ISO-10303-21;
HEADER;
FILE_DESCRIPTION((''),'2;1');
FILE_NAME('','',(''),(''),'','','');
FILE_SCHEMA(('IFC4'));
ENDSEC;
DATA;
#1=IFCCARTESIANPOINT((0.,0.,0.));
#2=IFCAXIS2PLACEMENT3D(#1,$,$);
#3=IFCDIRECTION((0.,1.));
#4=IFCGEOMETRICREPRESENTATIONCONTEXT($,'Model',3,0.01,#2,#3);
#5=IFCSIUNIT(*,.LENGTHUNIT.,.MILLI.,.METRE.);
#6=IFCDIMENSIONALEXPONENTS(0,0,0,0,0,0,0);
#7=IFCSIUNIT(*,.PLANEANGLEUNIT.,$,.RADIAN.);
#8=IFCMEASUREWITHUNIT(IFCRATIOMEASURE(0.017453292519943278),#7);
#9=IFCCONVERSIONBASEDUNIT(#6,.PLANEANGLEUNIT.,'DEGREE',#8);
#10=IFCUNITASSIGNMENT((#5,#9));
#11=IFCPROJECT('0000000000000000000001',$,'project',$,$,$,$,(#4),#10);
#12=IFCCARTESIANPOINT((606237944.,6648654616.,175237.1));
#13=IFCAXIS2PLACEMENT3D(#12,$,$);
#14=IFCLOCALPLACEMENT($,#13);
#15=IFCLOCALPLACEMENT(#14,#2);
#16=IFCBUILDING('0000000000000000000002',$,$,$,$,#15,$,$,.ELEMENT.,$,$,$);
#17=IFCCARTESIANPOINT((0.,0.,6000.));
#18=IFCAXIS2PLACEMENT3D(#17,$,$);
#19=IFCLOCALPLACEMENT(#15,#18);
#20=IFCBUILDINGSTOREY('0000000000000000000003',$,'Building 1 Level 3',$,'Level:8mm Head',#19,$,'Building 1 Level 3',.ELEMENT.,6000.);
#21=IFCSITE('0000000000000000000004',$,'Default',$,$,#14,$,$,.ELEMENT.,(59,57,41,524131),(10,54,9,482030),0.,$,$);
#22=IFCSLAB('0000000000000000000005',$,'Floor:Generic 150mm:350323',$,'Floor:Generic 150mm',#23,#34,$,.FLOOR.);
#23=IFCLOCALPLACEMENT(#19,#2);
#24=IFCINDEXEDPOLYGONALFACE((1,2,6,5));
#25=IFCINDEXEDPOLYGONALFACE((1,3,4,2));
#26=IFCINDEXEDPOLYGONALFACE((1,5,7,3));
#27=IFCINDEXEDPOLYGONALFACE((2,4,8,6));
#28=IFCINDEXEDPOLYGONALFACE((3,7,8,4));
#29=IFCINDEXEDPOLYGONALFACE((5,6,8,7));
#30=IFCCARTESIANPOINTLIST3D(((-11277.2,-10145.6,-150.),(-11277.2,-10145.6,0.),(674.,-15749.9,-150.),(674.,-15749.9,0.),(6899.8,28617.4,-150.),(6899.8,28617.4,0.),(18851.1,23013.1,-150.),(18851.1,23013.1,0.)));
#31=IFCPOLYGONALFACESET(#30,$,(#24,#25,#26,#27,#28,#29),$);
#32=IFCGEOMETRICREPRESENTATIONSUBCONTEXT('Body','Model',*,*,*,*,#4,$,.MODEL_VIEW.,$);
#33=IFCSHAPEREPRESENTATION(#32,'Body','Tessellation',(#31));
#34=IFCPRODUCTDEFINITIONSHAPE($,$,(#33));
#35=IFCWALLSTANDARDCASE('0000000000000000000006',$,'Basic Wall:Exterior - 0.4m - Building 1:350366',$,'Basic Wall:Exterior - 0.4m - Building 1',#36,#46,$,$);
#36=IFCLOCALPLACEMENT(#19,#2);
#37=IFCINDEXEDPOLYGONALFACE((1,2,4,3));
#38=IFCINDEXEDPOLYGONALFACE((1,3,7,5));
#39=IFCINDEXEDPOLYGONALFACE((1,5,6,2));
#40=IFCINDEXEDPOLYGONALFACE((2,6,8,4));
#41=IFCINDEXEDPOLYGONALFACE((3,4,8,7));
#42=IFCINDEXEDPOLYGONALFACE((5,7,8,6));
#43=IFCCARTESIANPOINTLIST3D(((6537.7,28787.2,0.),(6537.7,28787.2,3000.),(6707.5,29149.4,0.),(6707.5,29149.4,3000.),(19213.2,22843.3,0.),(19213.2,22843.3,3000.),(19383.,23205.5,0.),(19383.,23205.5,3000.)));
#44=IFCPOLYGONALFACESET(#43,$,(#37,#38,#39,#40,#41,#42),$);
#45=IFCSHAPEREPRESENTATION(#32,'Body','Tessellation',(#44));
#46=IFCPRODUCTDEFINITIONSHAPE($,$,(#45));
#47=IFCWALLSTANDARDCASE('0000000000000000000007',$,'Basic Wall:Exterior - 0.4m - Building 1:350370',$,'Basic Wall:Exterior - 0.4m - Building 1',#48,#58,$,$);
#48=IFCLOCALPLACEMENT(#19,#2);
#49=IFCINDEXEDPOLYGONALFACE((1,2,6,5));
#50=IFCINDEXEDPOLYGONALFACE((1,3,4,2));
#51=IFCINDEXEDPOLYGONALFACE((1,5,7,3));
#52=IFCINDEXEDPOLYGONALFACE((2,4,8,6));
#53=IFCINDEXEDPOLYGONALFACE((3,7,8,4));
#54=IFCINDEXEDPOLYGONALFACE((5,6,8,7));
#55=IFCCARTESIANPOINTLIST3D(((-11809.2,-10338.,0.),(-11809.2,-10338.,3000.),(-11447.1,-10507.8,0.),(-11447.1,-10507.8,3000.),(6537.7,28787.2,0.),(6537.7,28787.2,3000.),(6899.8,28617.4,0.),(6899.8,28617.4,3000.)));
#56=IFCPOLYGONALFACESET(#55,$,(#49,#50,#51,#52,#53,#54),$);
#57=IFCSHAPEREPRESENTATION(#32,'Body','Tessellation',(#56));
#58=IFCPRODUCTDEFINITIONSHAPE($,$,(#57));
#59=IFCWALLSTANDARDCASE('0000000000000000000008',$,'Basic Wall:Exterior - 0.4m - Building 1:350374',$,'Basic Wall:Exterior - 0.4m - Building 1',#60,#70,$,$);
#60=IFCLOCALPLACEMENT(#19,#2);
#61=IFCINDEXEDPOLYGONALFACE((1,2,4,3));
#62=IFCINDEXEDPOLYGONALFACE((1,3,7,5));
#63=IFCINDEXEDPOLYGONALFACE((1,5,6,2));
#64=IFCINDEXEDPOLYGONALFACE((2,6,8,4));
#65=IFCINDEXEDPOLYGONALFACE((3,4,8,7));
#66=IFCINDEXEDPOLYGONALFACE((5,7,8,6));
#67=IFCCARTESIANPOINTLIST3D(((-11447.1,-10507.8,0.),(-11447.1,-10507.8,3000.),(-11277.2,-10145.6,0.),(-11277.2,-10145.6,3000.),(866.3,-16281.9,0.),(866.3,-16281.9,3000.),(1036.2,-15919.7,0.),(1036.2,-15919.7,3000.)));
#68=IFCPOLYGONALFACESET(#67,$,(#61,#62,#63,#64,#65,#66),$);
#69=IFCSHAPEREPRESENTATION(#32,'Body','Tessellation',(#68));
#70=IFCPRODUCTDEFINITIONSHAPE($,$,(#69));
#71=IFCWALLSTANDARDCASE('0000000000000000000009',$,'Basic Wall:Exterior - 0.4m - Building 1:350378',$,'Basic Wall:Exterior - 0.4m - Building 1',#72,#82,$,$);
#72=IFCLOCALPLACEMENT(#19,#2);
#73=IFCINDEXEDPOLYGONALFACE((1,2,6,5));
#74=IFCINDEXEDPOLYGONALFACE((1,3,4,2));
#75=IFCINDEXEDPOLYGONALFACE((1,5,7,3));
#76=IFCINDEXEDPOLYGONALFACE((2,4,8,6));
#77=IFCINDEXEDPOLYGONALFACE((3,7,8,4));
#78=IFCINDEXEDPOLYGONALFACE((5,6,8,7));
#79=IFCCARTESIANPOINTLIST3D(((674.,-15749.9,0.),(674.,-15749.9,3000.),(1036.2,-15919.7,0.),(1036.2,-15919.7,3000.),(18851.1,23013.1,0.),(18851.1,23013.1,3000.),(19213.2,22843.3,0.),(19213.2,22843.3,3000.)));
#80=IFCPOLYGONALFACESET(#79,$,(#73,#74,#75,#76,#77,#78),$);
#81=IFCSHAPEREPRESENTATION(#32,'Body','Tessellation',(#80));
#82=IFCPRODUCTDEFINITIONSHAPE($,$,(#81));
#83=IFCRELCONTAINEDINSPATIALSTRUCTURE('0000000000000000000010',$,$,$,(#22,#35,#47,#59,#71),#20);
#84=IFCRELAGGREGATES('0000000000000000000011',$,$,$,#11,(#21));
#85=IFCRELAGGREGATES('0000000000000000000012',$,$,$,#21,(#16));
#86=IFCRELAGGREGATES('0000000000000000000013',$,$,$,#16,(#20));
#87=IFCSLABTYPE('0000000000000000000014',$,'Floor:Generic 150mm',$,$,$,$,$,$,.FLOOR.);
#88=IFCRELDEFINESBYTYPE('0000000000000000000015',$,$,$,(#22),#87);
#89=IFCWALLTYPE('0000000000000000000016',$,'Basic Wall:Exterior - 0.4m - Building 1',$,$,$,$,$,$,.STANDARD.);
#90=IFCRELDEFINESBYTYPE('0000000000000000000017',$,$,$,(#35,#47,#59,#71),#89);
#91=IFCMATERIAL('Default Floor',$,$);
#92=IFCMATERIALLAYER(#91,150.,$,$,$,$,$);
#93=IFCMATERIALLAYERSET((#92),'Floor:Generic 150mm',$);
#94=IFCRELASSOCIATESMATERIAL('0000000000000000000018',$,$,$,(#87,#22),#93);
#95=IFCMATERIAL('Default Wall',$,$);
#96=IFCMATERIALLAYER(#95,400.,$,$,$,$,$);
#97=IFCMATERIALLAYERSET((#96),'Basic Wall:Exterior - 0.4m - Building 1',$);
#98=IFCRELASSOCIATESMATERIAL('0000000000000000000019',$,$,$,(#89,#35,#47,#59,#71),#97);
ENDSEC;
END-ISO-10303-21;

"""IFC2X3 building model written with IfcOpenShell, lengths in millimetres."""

from ifc_helpers import new_model, entity, si_unit, converted_unit, direction, frame, frame_2d, origin, place, context, subcontext, project, spatial, rectangle, extrude, material, layer, layer_set, layer_usage, type_object, element, save


model = new_model("IFC2X3")

# Units and contexts
model_context = context("Model", 3, precision=0.01, world=origin(), true_north=direction((0.0, 1.0)))
body_context = subcontext(model_context, "Body", "Model", "MODEL_VIEW")
ifc_project = project(units=[si_unit("LENGTHUNIT", "METRE", prefix="MILLI"), converted_unit("PLANEANGLEUNIT", "DEGREE", entity("IfcRatioMeasure", 0.017453292519943278), si_unit("PLANEANGLEUNIT", "RADIAN"), dimensions=[0, 0, 0, 0, 0, 0, 0])], contexts=[model_context])

# Site, building, storey
site_placement = place(None, frame((606237944.0, 6648654616.0, 175237.1)))
site = spatial("IfcSite", under=ifc_project, at=site_placement, Name="Default", CompositionType="ELEMENT", RefLatitude=(59, 57, 41, 524131), RefLongitude=(10, 54, 9, 482030), RefElevation=0.0)
building_placement = place(site_placement, origin())
building = spatial("IfcBuilding", under=site, at=building_placement, CompositionType="ELEMENT")
storey_placement = place(building_placement, frame((0.0, 0.0, 6000.0)))
storey = spatial("IfcBuildingStorey", under=building, at=storey_placement, Name="Building 1 Level 3", ObjectType="Level:8mm Head", LongName="Building 1 Level 3", CompositionType="ELEMENT", Elevation=6000.0)

# Slab
ifc_material_1 = material(Name="Default Floor")
ifc_layer_1 = layer(ifc_material_1, 150.0)
ifc_layer_set_1 = layer_set([ifc_layer_1], Name="Floor:Generic 150mm")
ifc_layer_usage_1 = layer_usage(ifc_layer_set_1, "AXIS3", "POSITIVE", 0.0)
slab_type = type_object("IfcSlabType", Name="Floor:Generic 150mm", PredefinedType="FLOOR", material=ifc_layer_set_1)
slab_placement = place(storey_placement, origin())
element("IfcSlab", 1, at=slab_placement, inside=storey, type_object=slab_type, material=ifc_layer_usage_1, Name="Floor:Generic 150mm:350323", ObjectType="Floor:Generic 150mm", PredefinedType="FLOOR", context=body_context, shape_type="SweptSolid", body=[
    extrude(rectangle(XDim=13200.0, YDim=42813.3, at=frame_2d((0.0, 0.0), x_axis=(1.0, 0.0))), frame((3786.9, 6433.8, 0.0), z_axis=(0.0, 0.0, -1.0), x_axis=(0.905397, -0.424566, 0.0)), (0.0, 0.0, 1.0), 150.0),
])

# Walls
ifc_material_2 = material(Name="Default Wall")
ifc_layer_2 = layer(ifc_material_2, 400.0)
ifc_layer_set_2 = layer_set([ifc_layer_2], Name="Basic Wall:Exterior - 0.4m - Building 1")
ifc_layer_usage_2 = layer_usage(ifc_layer_set_2, "AXIS2", "POSITIVE", -200.0)
wall_type = type_object("IfcWallType", Name="Basic Wall:Exterior - 0.4m - Building 1", PredefinedType="STANDARD", material=ifc_layer_set_2)
wall_1_placement = place(storey_placement, frame((19298.1, 23024.4, 0.0), z_axis=(0.0, 0.0, 1.0), x_axis=(-0.905397, 0.424566, 0.0)))
element("IfcWallStandardCase", 2, at=wall_1_placement, inside=storey, type_object=wall_type, material=ifc_layer_usage_2, Name="Basic Wall:Exterior - 0.4m - Building 1:350366", ObjectType="Basic Wall:Exterior - 0.4m - Building 1", context=body_context, shape_type="SweptSolid", body=[
    extrude(rectangle(XDim=14000.0, YDim=400.0, at=frame_2d((7000.0, 0.0), x_axis=(-1.0, 0.0))), origin(), (0.0, 0.0, 1.0), 3000.0),
])
wall_2_placement = place(storey_placement, frame((6718.7, 28702.3, 0.0), z_axis=(0.0, 0.0, 1.0), x_axis=(-0.424566, -0.905397, 0.0)))
element("IfcWallStandardCase", 3, at=wall_2_placement, inside=storey, type_object=wall_type, material=ifc_layer_usage_2, Name="Basic Wall:Exterior - 0.4m - Building 1:350370", ObjectType="Basic Wall:Exterior - 0.4m - Building 1", context=body_context, shape_type="SweptSolid", body=[
    extrude(rectangle(XDim=43213.3, YDim=400.0, at=frame_2d((21606.7, 0.0), x_axis=(-1.0, 0.0))), origin(), (0.0, 0.0, 1.0), 3000.0),
])
wall_3_placement = place(storey_placement, frame((-11362.2, -10326.7, 0.0), z_axis=(0.0, 0.0, 1.0), x_axis=(0.905397, -0.424566, 0.0)))
element("IfcWallStandardCase", 4, at=wall_3_placement, inside=storey, type_object=wall_type, material=ifc_layer_usage_2, Name="Basic Wall:Exterior - 0.4m - Building 1:350374", ObjectType="Basic Wall:Exterior - 0.4m - Building 1", context=body_context, shape_type="SweptSolid", body=[
    extrude(rectangle(XDim=13600.0, YDim=400.0, at=frame_2d((6800.0, 0.0), x_axis=(-1.0, 0.0))), origin(), (0.0, 0.0, 1.0), 3000.0),
])
wall_4_placement = place(storey_placement, frame((855.1, -15834.8, 0.0), z_axis=(0.0, 0.0, 1.0), x_axis=(0.424566, 0.905397, 0.0)))
element("IfcWallStandardCase", 5, at=wall_4_placement, inside=storey, type_object=wall_type, material=ifc_layer_usage_2, Name="Basic Wall:Exterior - 0.4m - Building 1:350378", ObjectType="Basic Wall:Exterior - 0.4m - Building 1", context=body_context, shape_type="SweptSolid", body=[
    extrude(rectangle(XDim=42813.3, YDim=400.0, at=frame_2d((21406.7, 0.0), x_axis=(-1.0, 0.0))), origin(), (0.0, 0.0, 1.0), 3000.0),
])

save(model, "model.ifc")
